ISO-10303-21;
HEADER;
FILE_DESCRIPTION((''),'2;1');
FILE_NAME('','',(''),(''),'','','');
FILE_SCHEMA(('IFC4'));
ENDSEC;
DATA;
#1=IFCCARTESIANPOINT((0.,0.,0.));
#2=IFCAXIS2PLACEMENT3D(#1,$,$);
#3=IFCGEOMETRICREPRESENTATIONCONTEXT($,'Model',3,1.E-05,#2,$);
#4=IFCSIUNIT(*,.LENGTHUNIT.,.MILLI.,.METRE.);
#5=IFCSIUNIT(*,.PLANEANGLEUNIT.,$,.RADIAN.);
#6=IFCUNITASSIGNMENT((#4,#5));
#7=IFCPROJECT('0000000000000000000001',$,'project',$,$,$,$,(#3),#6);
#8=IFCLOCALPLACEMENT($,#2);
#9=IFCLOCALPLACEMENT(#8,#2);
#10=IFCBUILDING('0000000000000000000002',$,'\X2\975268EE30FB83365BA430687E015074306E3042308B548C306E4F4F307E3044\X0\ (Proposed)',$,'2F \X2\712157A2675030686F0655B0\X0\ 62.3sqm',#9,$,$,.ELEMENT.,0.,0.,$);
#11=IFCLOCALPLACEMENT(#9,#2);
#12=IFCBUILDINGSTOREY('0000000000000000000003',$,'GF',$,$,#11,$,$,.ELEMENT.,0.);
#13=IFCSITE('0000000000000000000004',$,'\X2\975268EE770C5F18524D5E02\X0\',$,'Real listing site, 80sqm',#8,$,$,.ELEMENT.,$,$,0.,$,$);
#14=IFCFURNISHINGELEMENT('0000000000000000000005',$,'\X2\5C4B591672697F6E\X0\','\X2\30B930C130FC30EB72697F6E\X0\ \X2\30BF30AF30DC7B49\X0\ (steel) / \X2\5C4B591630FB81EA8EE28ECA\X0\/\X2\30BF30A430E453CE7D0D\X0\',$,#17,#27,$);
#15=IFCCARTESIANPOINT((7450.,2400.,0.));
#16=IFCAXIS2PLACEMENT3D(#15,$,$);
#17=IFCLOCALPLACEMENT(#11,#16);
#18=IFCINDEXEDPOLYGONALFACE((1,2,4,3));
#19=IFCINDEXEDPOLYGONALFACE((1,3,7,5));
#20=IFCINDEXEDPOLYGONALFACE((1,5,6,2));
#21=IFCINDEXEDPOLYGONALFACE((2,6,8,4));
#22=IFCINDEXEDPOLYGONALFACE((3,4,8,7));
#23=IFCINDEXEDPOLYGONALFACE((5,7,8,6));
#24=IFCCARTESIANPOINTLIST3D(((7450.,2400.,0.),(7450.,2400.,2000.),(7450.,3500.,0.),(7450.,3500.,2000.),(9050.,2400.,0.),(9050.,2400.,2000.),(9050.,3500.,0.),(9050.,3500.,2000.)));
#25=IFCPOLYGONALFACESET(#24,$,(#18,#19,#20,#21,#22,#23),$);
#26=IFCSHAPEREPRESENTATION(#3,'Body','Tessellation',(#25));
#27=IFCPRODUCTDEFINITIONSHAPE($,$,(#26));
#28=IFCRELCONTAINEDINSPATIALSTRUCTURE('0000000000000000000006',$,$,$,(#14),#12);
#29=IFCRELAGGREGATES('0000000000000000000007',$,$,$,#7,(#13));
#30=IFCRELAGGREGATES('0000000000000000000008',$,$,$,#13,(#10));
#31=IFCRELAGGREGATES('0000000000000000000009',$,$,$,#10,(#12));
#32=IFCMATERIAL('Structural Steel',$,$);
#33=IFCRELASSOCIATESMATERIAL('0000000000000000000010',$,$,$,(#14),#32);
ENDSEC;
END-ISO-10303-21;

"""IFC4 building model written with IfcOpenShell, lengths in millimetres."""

from ifc_helpers import new_model, si_unit, frame, frame_2d, origin, place, context, project, spatial, rectangle, extrude, material, element, save


model = new_model("IFC4")

# Units and contexts
model_context = context("Model", 3, precision=1e-05, world=origin())
ifc_project = project(units=[si_unit("LENGTHUNIT", "METRE", prefix="MILLI"), si_unit("PLANEANGLEUNIT", "RADIAN")], contexts=[model_context])

# Site, building, storey
site_placement = place(None, origin())
site = spatial("IfcSite", under=ifc_project, at=site_placement, Name="青森県弘前市", ObjectType="Real listing site, 80sqm", CompositionType="ELEMENT", RefElevation=0.0)
building_placement = place(site_placement, origin())
building = spatial("IfcBuilding", under=site, at=building_placement, Name="青森・茶室と縁側のある和の住まい (Proposed)", ObjectType="2F 無垢材と漆喰 62.3sqm", CompositionType="ELEMENT", ElevationOfRefHeight=0.0, ElevationOfTerrain=0.0)
storey_placement = place(building_placement, origin())
storey = spatial("IfcBuildingStorey", under=building, at=storey_placement, Name="GF", CompositionType="ELEMENT", Elevation=0.0)

# Shared definitions
ifc_material_1 = material(Name="Structural Steel")

# Furnishing element
furnishing_1_placement = place(storey_placement, frame((7450.0, 2400.0, 0.0)))
element("IfcFurnishingElement", 1, at=furnishing_1_placement, inside=storey, material=ifc_material_1, Name="屋外物置", Description="スチール物置 タクボ等 (steel) / 屋外・自転車/タイヤ収納", context=model_context, shape_type="SweptSolid", body=[
    extrude(rectangle(XDim=1600.0, YDim=1100.0, at=frame_2d((800.0, 550.0))), frame((7450.0, 2400.0, 0.0)), (0.0, 0.0, 1.0), 2000.0),
])

save(model, "model.ifc")
